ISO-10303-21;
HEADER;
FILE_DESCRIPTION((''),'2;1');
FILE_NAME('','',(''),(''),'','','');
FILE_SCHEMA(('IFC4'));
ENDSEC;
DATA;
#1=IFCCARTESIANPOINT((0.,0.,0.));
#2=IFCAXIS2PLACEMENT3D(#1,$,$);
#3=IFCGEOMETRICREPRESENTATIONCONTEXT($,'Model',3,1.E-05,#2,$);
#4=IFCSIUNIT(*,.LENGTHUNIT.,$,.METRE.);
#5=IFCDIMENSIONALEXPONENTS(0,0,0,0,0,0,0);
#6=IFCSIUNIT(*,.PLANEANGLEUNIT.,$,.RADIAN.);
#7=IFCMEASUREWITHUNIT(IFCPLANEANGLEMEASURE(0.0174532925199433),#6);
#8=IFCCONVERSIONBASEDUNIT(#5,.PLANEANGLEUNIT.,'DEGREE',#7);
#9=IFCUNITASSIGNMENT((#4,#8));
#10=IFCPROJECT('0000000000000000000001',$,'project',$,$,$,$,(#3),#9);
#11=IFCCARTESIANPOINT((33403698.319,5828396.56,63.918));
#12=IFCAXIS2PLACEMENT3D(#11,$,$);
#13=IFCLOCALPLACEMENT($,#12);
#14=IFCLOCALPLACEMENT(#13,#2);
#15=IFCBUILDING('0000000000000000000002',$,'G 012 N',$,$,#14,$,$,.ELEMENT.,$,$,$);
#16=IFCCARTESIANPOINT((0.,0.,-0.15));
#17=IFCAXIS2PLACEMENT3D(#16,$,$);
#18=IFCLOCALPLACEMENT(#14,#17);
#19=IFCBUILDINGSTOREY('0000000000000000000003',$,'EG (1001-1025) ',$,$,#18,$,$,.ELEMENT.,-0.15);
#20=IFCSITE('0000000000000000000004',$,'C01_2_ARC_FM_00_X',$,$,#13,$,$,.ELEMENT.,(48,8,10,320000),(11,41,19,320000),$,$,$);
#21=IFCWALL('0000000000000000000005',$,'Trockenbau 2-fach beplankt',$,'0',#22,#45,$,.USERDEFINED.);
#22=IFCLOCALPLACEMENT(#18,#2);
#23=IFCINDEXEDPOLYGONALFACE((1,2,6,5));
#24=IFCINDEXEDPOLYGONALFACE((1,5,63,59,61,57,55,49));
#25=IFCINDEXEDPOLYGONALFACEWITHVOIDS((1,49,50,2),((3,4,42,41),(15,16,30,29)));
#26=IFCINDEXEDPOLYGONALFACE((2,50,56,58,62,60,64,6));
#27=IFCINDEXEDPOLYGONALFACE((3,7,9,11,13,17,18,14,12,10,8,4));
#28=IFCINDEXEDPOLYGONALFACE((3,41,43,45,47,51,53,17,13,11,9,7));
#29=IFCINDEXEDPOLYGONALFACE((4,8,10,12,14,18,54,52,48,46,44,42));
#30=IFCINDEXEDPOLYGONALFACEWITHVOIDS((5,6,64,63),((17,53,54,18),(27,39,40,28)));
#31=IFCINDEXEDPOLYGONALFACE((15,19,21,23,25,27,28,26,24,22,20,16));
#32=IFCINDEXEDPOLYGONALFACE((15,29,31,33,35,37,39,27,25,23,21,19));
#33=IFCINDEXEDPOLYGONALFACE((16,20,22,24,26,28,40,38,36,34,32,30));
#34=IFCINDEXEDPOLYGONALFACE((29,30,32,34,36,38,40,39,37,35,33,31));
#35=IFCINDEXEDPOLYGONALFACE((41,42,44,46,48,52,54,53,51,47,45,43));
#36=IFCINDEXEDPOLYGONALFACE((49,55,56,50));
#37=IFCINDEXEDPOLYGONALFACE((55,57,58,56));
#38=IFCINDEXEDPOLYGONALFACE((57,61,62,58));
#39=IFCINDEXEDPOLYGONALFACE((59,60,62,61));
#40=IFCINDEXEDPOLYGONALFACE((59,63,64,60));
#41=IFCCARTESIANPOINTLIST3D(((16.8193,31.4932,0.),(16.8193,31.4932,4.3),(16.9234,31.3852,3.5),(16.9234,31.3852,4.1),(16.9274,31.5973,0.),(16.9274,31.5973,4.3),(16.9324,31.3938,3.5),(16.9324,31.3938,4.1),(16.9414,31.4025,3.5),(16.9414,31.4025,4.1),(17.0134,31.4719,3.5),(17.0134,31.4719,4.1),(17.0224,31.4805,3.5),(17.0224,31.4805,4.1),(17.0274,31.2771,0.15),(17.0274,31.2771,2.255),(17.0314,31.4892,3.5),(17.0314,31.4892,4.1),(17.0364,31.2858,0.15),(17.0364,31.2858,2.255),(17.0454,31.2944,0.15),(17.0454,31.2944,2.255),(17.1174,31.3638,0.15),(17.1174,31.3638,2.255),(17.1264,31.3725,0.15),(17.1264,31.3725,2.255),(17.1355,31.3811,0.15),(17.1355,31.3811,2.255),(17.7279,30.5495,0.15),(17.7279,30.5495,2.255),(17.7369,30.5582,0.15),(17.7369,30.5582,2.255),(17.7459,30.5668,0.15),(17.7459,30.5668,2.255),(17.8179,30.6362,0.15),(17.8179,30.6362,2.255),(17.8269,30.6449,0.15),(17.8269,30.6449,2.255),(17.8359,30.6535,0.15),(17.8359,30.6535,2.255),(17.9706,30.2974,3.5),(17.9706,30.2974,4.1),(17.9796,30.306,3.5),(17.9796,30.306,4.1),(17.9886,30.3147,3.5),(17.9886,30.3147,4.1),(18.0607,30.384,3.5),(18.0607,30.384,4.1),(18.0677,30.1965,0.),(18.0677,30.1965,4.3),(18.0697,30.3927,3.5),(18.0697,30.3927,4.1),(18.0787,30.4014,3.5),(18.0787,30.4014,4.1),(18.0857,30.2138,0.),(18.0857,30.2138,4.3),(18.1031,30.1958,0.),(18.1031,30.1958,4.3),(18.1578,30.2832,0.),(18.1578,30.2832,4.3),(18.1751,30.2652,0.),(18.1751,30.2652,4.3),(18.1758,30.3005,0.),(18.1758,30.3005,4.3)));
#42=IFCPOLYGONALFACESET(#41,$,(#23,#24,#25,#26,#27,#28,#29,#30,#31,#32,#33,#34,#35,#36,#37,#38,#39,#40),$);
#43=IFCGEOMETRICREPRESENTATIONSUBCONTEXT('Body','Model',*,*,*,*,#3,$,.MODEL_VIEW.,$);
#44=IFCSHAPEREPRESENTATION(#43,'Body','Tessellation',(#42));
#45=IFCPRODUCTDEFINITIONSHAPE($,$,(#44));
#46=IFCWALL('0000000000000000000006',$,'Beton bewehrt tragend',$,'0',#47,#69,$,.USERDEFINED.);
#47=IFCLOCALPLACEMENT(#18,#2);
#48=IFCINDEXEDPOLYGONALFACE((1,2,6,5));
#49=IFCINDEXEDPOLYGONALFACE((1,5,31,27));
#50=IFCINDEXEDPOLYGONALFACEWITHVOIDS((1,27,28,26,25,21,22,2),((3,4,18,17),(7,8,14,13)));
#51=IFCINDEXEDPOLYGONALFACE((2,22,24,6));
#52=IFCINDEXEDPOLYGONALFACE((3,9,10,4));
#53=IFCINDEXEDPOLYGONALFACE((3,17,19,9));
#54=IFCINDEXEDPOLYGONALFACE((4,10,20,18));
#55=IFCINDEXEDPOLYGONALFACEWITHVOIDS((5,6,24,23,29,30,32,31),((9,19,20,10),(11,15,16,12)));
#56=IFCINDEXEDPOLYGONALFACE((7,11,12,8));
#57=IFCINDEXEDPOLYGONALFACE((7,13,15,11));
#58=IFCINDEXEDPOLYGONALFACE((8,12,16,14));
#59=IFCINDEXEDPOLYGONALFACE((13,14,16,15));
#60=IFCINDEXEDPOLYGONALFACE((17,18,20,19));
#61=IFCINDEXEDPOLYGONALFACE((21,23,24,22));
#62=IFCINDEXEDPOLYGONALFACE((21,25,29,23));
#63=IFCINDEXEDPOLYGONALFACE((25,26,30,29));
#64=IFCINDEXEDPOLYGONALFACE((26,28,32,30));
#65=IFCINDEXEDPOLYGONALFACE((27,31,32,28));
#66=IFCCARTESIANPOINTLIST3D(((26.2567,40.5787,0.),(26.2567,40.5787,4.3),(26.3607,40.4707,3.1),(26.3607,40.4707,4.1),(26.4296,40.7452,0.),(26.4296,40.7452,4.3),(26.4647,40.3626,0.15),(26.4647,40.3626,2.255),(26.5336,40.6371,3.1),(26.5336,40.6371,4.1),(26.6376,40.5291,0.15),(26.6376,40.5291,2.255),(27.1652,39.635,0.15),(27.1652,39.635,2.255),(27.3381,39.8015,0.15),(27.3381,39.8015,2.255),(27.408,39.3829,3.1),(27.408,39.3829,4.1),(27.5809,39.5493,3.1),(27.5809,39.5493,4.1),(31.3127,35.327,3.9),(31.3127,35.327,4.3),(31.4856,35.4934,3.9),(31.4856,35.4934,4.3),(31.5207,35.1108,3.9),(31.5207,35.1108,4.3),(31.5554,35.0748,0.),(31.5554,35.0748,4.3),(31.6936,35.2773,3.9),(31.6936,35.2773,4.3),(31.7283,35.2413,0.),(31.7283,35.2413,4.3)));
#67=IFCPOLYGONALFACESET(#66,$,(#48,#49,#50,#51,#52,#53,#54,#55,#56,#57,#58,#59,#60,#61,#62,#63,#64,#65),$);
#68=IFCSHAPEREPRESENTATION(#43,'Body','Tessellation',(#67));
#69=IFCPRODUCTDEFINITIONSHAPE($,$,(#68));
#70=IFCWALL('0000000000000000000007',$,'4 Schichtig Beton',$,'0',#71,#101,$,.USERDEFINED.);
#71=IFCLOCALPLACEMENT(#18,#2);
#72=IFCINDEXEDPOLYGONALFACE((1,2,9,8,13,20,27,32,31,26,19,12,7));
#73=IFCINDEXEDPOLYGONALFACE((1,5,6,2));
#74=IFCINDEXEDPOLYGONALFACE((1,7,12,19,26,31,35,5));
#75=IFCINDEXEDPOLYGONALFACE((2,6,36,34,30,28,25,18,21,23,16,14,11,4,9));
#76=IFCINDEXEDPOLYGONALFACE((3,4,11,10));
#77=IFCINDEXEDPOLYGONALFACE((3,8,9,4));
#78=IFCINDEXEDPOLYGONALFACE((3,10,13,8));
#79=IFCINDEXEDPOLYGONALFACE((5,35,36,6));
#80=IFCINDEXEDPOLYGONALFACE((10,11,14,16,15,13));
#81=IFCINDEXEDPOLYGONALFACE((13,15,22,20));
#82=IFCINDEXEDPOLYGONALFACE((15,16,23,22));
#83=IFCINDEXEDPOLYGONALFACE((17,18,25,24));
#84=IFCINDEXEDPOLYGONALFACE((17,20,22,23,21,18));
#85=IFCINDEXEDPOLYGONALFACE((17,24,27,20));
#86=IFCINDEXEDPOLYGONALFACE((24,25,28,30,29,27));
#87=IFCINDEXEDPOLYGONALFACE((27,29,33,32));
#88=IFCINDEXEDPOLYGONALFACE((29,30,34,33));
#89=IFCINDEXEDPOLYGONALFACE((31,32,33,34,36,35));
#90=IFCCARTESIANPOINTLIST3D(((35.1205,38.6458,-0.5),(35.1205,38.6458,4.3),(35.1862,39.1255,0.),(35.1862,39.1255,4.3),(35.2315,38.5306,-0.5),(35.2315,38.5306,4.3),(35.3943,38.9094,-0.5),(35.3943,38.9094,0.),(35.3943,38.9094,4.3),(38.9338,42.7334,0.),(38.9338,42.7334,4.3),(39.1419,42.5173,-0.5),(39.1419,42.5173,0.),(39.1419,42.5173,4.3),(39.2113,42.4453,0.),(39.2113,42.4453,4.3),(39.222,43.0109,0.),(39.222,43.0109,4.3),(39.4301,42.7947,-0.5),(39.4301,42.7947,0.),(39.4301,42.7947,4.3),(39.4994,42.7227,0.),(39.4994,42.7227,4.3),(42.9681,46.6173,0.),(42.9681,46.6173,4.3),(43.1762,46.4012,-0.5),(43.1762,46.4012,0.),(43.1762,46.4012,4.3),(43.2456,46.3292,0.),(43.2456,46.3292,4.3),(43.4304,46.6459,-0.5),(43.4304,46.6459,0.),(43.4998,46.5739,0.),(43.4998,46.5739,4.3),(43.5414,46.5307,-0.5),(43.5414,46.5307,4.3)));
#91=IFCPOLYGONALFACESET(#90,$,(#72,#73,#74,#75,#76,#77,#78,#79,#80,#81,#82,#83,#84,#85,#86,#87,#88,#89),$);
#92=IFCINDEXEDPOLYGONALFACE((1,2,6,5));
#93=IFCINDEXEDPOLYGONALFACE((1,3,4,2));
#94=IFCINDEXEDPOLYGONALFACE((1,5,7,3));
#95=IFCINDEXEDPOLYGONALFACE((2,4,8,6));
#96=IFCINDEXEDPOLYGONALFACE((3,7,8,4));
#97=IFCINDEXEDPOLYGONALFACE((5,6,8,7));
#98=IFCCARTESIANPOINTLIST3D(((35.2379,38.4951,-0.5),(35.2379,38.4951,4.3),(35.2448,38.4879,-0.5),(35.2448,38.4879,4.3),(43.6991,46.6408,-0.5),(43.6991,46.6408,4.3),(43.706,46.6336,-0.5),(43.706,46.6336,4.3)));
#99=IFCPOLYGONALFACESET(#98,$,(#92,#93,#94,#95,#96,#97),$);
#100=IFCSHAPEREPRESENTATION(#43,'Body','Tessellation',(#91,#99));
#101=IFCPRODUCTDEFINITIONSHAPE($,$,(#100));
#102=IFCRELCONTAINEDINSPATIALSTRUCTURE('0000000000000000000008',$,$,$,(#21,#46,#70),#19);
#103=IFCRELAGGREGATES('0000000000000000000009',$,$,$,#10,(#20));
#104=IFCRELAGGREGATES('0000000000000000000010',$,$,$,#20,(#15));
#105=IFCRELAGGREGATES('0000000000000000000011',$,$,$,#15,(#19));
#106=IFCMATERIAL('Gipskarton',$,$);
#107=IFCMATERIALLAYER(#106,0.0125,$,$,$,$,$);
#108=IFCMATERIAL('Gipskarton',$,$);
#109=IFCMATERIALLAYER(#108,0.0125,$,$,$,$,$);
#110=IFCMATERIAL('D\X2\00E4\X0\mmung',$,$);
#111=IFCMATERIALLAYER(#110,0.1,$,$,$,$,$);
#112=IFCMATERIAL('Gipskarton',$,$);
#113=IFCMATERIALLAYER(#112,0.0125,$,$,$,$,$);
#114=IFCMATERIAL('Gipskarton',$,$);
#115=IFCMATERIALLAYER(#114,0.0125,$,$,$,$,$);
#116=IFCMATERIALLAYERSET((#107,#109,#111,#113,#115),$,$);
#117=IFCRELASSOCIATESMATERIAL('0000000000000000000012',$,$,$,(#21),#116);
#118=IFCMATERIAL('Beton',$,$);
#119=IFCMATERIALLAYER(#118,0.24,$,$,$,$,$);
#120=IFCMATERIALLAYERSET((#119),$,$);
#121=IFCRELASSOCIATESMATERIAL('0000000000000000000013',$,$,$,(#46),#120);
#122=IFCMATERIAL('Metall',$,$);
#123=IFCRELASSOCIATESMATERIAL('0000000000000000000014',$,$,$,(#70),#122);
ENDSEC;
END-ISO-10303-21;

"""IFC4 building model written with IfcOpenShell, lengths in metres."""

from ifc_helpers import new_model, entity, si_unit, converted_unit, frame, frame_2d, origin, origin_with_axes, place, context, subcontext, project, spatial, polyline, rectangle, outline, extrude, clip, bounded_halfspace, material, layer, layer_set, layer_usage, element, save


model = new_model("IFC4")

# Units and contexts
model_context = context("Model", 3, precision=1e-05, world=origin())
body_context = subcontext(model_context, "Body", "Model", "MODEL_VIEW")
ifc_project = project(units=[si_unit("LENGTHUNIT", "METRE"), converted_unit("PLANEANGLEUNIT", "DEGREE", entity("IfcPlaneAngleMeasure", 0.0174532925199433), si_unit("PLANEANGLEUNIT", "RADIAN"), dimensions=[0, 0, 0, 0, 0, 0, 0])], contexts=[model_context])

# Site, building, storey
site_placement = place(None, frame((33403698.319, 5828396.56, 63.918)))
site = spatial("IfcSite", under=ifc_project, at=site_placement, Name="C01_2_ARC_FM_00_X", CompositionType="ELEMENT", RefLatitude=(48, 8, 10, 320000), RefLongitude=(11, 41, 19, 320000))
building_placement = place(site_placement, origin())
building = spatial("IfcBuilding", under=site, at=building_placement, Name="G 012 N", CompositionType="ELEMENT")
storey_placement = place(building_placement, frame((0.0, 0.0, -0.15)))
storey = spatial("IfcBuildingStorey", under=building, at=storey_placement, Name="EG (1001-1025) ", CompositionType="ELEMENT", Elevation=-0.15)

# Walls, openings
ifc_material_1 = material(Name="Gipskarton")
ifc_layer_1 = layer(ifc_material_1, 0.0125)
ifc_material_2 = material(Name="Gipskarton")
ifc_layer_2 = layer(ifc_material_2, 0.0125)
ifc_material_3 = material(Name="Dämmung")
ifc_layer_3 = layer(ifc_material_3, 0.1)
ifc_material_4 = material(Name="Gipskarton")
ifc_layer_4 = layer(ifc_material_4, 0.0125)
ifc_material_5 = material(Name="Gipskarton")
ifc_layer_5 = layer(ifc_material_5, 0.0125)
ifc_layer_set_1 = layer_set([ifc_layer_1, ifc_layer_2, ifc_layer_3, ifc_layer_4, ifc_layer_5])
ifc_layer_usage_1 = layer_usage(ifc_layer_set_1, "AXIS2", "POSITIVE", 0.0)
wall_1_placement = place(storey_placement, frame((16.8193, 31.4932, 0.0), z_axis=(0.0, 0.0, 1.0), x_axis=(0.693551, -0.720408, 0.0)))
wall_1 = element("IfcWall", 1, at=wall_1_placement, inside=storey, material=ifc_layer_usage_1, Name="Trockenbau 2-fach beplankt", ObjectType="0", PredefinedType="USERDEFINED", context=body_context, shape_type="SweptSolid", body=[
    extrude(outline(polyline([(-0.9347, 0.8998), (0.8653, 0.8998), (0.8653, 0.9248), (0.8903, 0.9248), (0.8903, 1.0248), (0.8653, 1.0248), (0.8653, 1.0498), (-0.9347, 1.0498), (-0.9347, 0.8998)])), frame((0.9347, -0.8998, 0.0), z_axis=(0.0, 0.0, 1.0), x_axis=(1.0, 0.0, 0.0)), (0.0, 0.0, 1.0), 4.3),
])
opening_1_placement = place(wall_1_placement, frame((0.3, 0.0, 0.15), z_axis=(0.0, 1.0, 0.0), x_axis=(0.0, 0.0, 1.0)))
element("IfcOpeningElement", 2, at=opening_1_placement, cuts=wall_1, ObjectType="0", PredefinedType="USERDEFINED", context=body_context, shape_type="SweptSolid", body=[
    extrude(outline(polyline([(0.0, 1.01), (2.105, 1.01), (2.105, 0.0), (0.0, 0.0), (0.0, 1.01)])), origin_with_axes(), (0.0, 0.0, 1.0), 0.0125),
    extrude(outline(polyline([(0.0, 1.01), (2.105, 1.01), (2.105, 0.0), (0.0, 0.0), (0.0, 1.01)])), frame((0.0, 0.0, 0.0125), z_axis=(0.0, 0.0, 1.0), x_axis=(1.0, 0.0, 0.0)), (0.0, 0.0, 1.0), 0.0125),
    extrude(outline(polyline([(0.0, 1.01), (2.105, 1.01), (2.105, 0.0), (0.0, 0.0), (0.0, 1.01)])), frame((0.0, 0.0, 0.025), z_axis=(0.0, 0.0, 1.0), x_axis=(1.0, 0.0, 0.0)), (0.0, 0.0, 1.0), 0.1),
    extrude(outline(polyline([(0.0, 1.01), (2.105, 1.01), (2.105, 0.0), (0.0, 0.0), (0.0, 1.01)])), frame((0.0, 0.0, 0.125), z_axis=(0.0, 0.0, 1.0), x_axis=(1.0, 0.0, 0.0)), (0.0, 0.0, 1.0), 0.0125),
    extrude(outline(polyline([(0.0, 1.01), (2.105, 1.01), (2.105, 0.0), (0.0, 0.0), (0.0, 1.01)])), frame((0.0, 0.0, 0.1375), z_axis=(0.0, 0.0, 1.0), x_axis=(1.0, 0.0, 0.0)), (0.0, 0.0, 1.0), 0.0125),
])
opening_2_placement = place(wall_1_placement, frame((0.15, 0.0, 3.5), z_axis=(0.0, 1.0, 0.0), x_axis=(0.0, 0.0, 1.0)))
element("IfcOpeningElement", 3, at=opening_2_placement, cuts=wall_1, ObjectType="Opening", context=body_context, shape_type="SweptSolid", body=[
    extrude(outline(polyline([(0.0, 1.51), (0.6, 1.51), (0.6, 0.0), (0.0, 0.0), (0.0, 1.51)])), origin_with_axes(), (0.0, 0.0, 1.0), 0.0125),
    extrude(outline(polyline([(0.0, 1.51), (0.6, 1.51), (0.6, 0.0), (0.0, 0.0), (0.0, 1.51)])), frame((0.0, 0.0, 0.0125), z_axis=(0.0, 0.0, 1.0), x_axis=(1.0, 0.0, 0.0)), (0.0, 0.0, 1.0), 0.0125),
    extrude(outline(polyline([(0.0, 1.51), (0.6, 1.51), (0.6, 0.0), (0.0, 0.0), (0.0, 1.51)])), frame((0.0, 0.0, 0.025), z_axis=(0.0, 0.0, 1.0), x_axis=(1.0, 0.0, 0.0)), (0.0, 0.0, 1.0), 0.1),
    extrude(outline(polyline([(0.0, 1.51), (0.6, 1.51), (0.6, 0.0), (0.0, 0.0), (0.0, 1.51)])), frame((0.0, 0.0, 0.125), z_axis=(0.0, 0.0, 1.0), x_axis=(1.0, 0.0, 0.0)), (0.0, 0.0, 1.0), 0.0125),
    extrude(outline(polyline([(0.0, 1.51), (0.6, 1.51), (0.6, 0.0), (0.0, 0.0), (0.0, 1.51)])), frame((0.0, 0.0, 0.1375), z_axis=(0.0, 0.0, 1.0), x_axis=(1.0, 0.0, 0.0)), (0.0, 0.0, 1.0), 0.0125),
])
ifc_material_6 = material(Name="Beton")
ifc_layer_6 = layer(ifc_material_6, 0.24)
ifc_layer_set_2 = layer_set([ifc_layer_6])
ifc_layer_usage_2 = layer_usage(ifc_layer_set_2, "AXIS2", "POSITIVE", 0.0)
wall_2_placement = place(storey_placement, frame((26.2567, 40.5787, 0.0), z_axis=(0.0, 0.0, 1.0), x_axis=(0.693551, -0.720408, 0.0)))
wall_2 = element("IfcWall", 4, at=wall_2_placement, inside=storey, material=ifc_layer_usage_2, Name="Beton bewehrt tragend", ObjectType="0", PredefinedType="USERDEFINED", context=body_context, shape_type="Clipping", body=[
    clip(extrude(rectangle(XDim=7.64, YDim=0.24, at=frame_2d((3.82, 0.12), x_axis=(1.0, 0.0))), origin_with_axes(), (0.0, 0.0, 1.0), 4.3), bounded_halfspace(frame((7.44, 0.12, 3.9), z_axis=(0.0, 0.0, -1.0), x_axis=(1.0, 0.0, 0.0)), True, origin_with_axes(), polyline([(7.29, 0.0), (7.59, 0.0), (7.59, 0.24), (7.29, 0.24), (7.29, 0.0)]))),
])
opening_3_placement = place(wall_2_placement, frame((0.3, 0.0, 0.15), z_axis=(0.0, 1.0, 0.0), x_axis=(0.0, 0.0, 1.0)))
element("IfcOpeningElement", 5, at=opening_3_placement, cuts=wall_2, ObjectType="Opening", context=body_context, shape_type="SweptSolid", body=[
    extrude(outline(polyline([(0.0, 1.01), (2.105, 1.01), (2.105, 0.0), (0.0, 0.0), (0.0, 1.01)])), origin_with_axes(), (0.0, 0.0, 1.0), 0.24),
])
opening_4_placement = place(wall_2_placement, frame((0.15, 0.0, 3.1), z_axis=(0.0, 1.0, 0.0), x_axis=(0.0, 0.0, 1.0)))
element("IfcOpeningElement", 6, at=opening_4_placement, cuts=wall_2, ObjectType="Opening", context=body_context, shape_type="SweptSolid", body=[
    extrude(outline(polyline([(0.0, 1.51), (1.0, 1.51), (1.0, 0.0), (0.0, 0.0), (0.0, 1.51)])), origin_with_axes(), (0.0, 0.0, 1.0), 0.24),
])

# Wall
ifc_material_7 = material(Name="Metall")
wall_3_placement = place(storey_placement, frame((35.2448, 38.4879, -0.5), z_axis=(0.0, 0.0, 1.0), x_axis=(0.720408, 0.693551, 0.0)))
element("IfcWall", 7, at=wall_3_placement, inside=storey, material=ifc_material_7, Name="4 Schichtig Beton", ObjectType="0", PredefinedType="USERDEFINED", context=body_context, shape_type="Clipping", body=[
    clip(clip(clip(clip(extrude(outline(polyline([(0.0799, -0.077), (11.6149, -0.077), (11.6149, 0.083), (11.2621, 0.083), (11.2621, 0.383), (6.0621, 0.383), (6.0621, 0.083), (5.6621, 0.083), (5.6621, 0.383), (0.4599, 0.383), (0.4599, 0.083), (0.0799, 0.083), (0.0799, -0.077)])), frame((-0.0599, 0.117, 0.0), z_axis=(0.0, 0.0, 1.0), x_axis=(1.0, 0.0, 0.0)), (0.0, 0.0, 1.0), 4.8), bounded_halfspace(frame((3.0011, 0.35, 0.5), z_axis=(0.0, 0.0, 1.0), x_axis=(1.0, 0.0, 0.0)), True, origin_with_axes(), polyline([(0.4, 0.2), (5.6021, 0.2), (5.6021, 0.5), (0.4, 0.5), (0.4, 0.2)]))), bounded_halfspace(frame((8.6021, 0.35, 0.5), z_axis=(0.0, 0.0, 1.0), x_axis=(0.0, -1.0, 0.0)), True, origin_with_axes(), polyline([(6.0021, 0.5), (6.0021, 0.2), (11.2021, 0.2), (11.2021, 0.5), (6.0021, 0.5)]))), bounded_halfspace(frame((11.3786, 0.15, 0.5), z_axis=(0.0, 0.0, -1.0), x_axis=(0.0, -1.0, 0.0)), True, origin_with_axes(), polyline([(11.2021, 0.2), (11.2021, 0.1), (11.555, 0.1), (11.555, 0.2), (11.2021, 0.2)]))), bounded_halfspace(frame((5.8021, 0.15, 0.5), z_axis=(0.0, 0.0, -1.0), x_axis=(0.0, -1.0, 0.0)), True, origin_with_axes(), polyline([(5.6021, 0.2), (5.6021, 0.1), (6.0021, 0.1), (6.0021, 0.2), (5.6021, 0.2)]))),
    clip(clip(clip(clip(extrude(rectangle(XDim=0.01, YDim=11.745, at=frame_2d((-5.8725, 0.005), x_axis=(0.0, 1.0))), frame((11.745, 0.0, 0.0), z_axis=(0.0, 0.0, 1.0), x_axis=(1.0, 0.0, 0.0)), (0.0, 0.0, 1.0), 4.8), bounded_halfspace(frame((3.0011, 0.35, 0.5), z_axis=(0.0, 0.0, 1.0), x_axis=(1.0, 0.0, 0.0)), True, origin_with_axes(), polyline([(0.4, 0.2), (5.6021, 0.2), (5.6021, 0.5), (0.4, 0.5), (0.4, 0.2)]))), bounded_halfspace(frame((8.6021, 0.35, 0.5), z_axis=(0.0, 0.0, 1.0), x_axis=(0.0, -1.0, 0.0)), True, origin_with_axes(), polyline([(6.0021, 0.5), (6.0021, 0.2), (11.2021, 0.2), (11.2021, 0.5), (6.0021, 0.5)]))), bounded_halfspace(frame((11.3786, 0.15, 0.5), z_axis=(0.0, 0.0, -1.0), x_axis=(0.0, -1.0, 0.0)), True, origin_with_axes(), polyline([(11.2021, 0.2), (11.2021, 0.1), (11.555, 0.1), (11.555, 0.2), (11.2021, 0.2)]))), bounded_halfspace(frame((5.8021, 0.15, 0.5), z_axis=(0.0, 0.0, -1.0), x_axis=(0.0, -1.0, 0.0)), True, origin_with_axes(), polyline([(5.6021, 0.2), (5.6021, 0.1), (6.0021, 0.1), (6.0021, 0.2), (5.6021, 0.2)]))),
])

save(model, "model.ifc")
